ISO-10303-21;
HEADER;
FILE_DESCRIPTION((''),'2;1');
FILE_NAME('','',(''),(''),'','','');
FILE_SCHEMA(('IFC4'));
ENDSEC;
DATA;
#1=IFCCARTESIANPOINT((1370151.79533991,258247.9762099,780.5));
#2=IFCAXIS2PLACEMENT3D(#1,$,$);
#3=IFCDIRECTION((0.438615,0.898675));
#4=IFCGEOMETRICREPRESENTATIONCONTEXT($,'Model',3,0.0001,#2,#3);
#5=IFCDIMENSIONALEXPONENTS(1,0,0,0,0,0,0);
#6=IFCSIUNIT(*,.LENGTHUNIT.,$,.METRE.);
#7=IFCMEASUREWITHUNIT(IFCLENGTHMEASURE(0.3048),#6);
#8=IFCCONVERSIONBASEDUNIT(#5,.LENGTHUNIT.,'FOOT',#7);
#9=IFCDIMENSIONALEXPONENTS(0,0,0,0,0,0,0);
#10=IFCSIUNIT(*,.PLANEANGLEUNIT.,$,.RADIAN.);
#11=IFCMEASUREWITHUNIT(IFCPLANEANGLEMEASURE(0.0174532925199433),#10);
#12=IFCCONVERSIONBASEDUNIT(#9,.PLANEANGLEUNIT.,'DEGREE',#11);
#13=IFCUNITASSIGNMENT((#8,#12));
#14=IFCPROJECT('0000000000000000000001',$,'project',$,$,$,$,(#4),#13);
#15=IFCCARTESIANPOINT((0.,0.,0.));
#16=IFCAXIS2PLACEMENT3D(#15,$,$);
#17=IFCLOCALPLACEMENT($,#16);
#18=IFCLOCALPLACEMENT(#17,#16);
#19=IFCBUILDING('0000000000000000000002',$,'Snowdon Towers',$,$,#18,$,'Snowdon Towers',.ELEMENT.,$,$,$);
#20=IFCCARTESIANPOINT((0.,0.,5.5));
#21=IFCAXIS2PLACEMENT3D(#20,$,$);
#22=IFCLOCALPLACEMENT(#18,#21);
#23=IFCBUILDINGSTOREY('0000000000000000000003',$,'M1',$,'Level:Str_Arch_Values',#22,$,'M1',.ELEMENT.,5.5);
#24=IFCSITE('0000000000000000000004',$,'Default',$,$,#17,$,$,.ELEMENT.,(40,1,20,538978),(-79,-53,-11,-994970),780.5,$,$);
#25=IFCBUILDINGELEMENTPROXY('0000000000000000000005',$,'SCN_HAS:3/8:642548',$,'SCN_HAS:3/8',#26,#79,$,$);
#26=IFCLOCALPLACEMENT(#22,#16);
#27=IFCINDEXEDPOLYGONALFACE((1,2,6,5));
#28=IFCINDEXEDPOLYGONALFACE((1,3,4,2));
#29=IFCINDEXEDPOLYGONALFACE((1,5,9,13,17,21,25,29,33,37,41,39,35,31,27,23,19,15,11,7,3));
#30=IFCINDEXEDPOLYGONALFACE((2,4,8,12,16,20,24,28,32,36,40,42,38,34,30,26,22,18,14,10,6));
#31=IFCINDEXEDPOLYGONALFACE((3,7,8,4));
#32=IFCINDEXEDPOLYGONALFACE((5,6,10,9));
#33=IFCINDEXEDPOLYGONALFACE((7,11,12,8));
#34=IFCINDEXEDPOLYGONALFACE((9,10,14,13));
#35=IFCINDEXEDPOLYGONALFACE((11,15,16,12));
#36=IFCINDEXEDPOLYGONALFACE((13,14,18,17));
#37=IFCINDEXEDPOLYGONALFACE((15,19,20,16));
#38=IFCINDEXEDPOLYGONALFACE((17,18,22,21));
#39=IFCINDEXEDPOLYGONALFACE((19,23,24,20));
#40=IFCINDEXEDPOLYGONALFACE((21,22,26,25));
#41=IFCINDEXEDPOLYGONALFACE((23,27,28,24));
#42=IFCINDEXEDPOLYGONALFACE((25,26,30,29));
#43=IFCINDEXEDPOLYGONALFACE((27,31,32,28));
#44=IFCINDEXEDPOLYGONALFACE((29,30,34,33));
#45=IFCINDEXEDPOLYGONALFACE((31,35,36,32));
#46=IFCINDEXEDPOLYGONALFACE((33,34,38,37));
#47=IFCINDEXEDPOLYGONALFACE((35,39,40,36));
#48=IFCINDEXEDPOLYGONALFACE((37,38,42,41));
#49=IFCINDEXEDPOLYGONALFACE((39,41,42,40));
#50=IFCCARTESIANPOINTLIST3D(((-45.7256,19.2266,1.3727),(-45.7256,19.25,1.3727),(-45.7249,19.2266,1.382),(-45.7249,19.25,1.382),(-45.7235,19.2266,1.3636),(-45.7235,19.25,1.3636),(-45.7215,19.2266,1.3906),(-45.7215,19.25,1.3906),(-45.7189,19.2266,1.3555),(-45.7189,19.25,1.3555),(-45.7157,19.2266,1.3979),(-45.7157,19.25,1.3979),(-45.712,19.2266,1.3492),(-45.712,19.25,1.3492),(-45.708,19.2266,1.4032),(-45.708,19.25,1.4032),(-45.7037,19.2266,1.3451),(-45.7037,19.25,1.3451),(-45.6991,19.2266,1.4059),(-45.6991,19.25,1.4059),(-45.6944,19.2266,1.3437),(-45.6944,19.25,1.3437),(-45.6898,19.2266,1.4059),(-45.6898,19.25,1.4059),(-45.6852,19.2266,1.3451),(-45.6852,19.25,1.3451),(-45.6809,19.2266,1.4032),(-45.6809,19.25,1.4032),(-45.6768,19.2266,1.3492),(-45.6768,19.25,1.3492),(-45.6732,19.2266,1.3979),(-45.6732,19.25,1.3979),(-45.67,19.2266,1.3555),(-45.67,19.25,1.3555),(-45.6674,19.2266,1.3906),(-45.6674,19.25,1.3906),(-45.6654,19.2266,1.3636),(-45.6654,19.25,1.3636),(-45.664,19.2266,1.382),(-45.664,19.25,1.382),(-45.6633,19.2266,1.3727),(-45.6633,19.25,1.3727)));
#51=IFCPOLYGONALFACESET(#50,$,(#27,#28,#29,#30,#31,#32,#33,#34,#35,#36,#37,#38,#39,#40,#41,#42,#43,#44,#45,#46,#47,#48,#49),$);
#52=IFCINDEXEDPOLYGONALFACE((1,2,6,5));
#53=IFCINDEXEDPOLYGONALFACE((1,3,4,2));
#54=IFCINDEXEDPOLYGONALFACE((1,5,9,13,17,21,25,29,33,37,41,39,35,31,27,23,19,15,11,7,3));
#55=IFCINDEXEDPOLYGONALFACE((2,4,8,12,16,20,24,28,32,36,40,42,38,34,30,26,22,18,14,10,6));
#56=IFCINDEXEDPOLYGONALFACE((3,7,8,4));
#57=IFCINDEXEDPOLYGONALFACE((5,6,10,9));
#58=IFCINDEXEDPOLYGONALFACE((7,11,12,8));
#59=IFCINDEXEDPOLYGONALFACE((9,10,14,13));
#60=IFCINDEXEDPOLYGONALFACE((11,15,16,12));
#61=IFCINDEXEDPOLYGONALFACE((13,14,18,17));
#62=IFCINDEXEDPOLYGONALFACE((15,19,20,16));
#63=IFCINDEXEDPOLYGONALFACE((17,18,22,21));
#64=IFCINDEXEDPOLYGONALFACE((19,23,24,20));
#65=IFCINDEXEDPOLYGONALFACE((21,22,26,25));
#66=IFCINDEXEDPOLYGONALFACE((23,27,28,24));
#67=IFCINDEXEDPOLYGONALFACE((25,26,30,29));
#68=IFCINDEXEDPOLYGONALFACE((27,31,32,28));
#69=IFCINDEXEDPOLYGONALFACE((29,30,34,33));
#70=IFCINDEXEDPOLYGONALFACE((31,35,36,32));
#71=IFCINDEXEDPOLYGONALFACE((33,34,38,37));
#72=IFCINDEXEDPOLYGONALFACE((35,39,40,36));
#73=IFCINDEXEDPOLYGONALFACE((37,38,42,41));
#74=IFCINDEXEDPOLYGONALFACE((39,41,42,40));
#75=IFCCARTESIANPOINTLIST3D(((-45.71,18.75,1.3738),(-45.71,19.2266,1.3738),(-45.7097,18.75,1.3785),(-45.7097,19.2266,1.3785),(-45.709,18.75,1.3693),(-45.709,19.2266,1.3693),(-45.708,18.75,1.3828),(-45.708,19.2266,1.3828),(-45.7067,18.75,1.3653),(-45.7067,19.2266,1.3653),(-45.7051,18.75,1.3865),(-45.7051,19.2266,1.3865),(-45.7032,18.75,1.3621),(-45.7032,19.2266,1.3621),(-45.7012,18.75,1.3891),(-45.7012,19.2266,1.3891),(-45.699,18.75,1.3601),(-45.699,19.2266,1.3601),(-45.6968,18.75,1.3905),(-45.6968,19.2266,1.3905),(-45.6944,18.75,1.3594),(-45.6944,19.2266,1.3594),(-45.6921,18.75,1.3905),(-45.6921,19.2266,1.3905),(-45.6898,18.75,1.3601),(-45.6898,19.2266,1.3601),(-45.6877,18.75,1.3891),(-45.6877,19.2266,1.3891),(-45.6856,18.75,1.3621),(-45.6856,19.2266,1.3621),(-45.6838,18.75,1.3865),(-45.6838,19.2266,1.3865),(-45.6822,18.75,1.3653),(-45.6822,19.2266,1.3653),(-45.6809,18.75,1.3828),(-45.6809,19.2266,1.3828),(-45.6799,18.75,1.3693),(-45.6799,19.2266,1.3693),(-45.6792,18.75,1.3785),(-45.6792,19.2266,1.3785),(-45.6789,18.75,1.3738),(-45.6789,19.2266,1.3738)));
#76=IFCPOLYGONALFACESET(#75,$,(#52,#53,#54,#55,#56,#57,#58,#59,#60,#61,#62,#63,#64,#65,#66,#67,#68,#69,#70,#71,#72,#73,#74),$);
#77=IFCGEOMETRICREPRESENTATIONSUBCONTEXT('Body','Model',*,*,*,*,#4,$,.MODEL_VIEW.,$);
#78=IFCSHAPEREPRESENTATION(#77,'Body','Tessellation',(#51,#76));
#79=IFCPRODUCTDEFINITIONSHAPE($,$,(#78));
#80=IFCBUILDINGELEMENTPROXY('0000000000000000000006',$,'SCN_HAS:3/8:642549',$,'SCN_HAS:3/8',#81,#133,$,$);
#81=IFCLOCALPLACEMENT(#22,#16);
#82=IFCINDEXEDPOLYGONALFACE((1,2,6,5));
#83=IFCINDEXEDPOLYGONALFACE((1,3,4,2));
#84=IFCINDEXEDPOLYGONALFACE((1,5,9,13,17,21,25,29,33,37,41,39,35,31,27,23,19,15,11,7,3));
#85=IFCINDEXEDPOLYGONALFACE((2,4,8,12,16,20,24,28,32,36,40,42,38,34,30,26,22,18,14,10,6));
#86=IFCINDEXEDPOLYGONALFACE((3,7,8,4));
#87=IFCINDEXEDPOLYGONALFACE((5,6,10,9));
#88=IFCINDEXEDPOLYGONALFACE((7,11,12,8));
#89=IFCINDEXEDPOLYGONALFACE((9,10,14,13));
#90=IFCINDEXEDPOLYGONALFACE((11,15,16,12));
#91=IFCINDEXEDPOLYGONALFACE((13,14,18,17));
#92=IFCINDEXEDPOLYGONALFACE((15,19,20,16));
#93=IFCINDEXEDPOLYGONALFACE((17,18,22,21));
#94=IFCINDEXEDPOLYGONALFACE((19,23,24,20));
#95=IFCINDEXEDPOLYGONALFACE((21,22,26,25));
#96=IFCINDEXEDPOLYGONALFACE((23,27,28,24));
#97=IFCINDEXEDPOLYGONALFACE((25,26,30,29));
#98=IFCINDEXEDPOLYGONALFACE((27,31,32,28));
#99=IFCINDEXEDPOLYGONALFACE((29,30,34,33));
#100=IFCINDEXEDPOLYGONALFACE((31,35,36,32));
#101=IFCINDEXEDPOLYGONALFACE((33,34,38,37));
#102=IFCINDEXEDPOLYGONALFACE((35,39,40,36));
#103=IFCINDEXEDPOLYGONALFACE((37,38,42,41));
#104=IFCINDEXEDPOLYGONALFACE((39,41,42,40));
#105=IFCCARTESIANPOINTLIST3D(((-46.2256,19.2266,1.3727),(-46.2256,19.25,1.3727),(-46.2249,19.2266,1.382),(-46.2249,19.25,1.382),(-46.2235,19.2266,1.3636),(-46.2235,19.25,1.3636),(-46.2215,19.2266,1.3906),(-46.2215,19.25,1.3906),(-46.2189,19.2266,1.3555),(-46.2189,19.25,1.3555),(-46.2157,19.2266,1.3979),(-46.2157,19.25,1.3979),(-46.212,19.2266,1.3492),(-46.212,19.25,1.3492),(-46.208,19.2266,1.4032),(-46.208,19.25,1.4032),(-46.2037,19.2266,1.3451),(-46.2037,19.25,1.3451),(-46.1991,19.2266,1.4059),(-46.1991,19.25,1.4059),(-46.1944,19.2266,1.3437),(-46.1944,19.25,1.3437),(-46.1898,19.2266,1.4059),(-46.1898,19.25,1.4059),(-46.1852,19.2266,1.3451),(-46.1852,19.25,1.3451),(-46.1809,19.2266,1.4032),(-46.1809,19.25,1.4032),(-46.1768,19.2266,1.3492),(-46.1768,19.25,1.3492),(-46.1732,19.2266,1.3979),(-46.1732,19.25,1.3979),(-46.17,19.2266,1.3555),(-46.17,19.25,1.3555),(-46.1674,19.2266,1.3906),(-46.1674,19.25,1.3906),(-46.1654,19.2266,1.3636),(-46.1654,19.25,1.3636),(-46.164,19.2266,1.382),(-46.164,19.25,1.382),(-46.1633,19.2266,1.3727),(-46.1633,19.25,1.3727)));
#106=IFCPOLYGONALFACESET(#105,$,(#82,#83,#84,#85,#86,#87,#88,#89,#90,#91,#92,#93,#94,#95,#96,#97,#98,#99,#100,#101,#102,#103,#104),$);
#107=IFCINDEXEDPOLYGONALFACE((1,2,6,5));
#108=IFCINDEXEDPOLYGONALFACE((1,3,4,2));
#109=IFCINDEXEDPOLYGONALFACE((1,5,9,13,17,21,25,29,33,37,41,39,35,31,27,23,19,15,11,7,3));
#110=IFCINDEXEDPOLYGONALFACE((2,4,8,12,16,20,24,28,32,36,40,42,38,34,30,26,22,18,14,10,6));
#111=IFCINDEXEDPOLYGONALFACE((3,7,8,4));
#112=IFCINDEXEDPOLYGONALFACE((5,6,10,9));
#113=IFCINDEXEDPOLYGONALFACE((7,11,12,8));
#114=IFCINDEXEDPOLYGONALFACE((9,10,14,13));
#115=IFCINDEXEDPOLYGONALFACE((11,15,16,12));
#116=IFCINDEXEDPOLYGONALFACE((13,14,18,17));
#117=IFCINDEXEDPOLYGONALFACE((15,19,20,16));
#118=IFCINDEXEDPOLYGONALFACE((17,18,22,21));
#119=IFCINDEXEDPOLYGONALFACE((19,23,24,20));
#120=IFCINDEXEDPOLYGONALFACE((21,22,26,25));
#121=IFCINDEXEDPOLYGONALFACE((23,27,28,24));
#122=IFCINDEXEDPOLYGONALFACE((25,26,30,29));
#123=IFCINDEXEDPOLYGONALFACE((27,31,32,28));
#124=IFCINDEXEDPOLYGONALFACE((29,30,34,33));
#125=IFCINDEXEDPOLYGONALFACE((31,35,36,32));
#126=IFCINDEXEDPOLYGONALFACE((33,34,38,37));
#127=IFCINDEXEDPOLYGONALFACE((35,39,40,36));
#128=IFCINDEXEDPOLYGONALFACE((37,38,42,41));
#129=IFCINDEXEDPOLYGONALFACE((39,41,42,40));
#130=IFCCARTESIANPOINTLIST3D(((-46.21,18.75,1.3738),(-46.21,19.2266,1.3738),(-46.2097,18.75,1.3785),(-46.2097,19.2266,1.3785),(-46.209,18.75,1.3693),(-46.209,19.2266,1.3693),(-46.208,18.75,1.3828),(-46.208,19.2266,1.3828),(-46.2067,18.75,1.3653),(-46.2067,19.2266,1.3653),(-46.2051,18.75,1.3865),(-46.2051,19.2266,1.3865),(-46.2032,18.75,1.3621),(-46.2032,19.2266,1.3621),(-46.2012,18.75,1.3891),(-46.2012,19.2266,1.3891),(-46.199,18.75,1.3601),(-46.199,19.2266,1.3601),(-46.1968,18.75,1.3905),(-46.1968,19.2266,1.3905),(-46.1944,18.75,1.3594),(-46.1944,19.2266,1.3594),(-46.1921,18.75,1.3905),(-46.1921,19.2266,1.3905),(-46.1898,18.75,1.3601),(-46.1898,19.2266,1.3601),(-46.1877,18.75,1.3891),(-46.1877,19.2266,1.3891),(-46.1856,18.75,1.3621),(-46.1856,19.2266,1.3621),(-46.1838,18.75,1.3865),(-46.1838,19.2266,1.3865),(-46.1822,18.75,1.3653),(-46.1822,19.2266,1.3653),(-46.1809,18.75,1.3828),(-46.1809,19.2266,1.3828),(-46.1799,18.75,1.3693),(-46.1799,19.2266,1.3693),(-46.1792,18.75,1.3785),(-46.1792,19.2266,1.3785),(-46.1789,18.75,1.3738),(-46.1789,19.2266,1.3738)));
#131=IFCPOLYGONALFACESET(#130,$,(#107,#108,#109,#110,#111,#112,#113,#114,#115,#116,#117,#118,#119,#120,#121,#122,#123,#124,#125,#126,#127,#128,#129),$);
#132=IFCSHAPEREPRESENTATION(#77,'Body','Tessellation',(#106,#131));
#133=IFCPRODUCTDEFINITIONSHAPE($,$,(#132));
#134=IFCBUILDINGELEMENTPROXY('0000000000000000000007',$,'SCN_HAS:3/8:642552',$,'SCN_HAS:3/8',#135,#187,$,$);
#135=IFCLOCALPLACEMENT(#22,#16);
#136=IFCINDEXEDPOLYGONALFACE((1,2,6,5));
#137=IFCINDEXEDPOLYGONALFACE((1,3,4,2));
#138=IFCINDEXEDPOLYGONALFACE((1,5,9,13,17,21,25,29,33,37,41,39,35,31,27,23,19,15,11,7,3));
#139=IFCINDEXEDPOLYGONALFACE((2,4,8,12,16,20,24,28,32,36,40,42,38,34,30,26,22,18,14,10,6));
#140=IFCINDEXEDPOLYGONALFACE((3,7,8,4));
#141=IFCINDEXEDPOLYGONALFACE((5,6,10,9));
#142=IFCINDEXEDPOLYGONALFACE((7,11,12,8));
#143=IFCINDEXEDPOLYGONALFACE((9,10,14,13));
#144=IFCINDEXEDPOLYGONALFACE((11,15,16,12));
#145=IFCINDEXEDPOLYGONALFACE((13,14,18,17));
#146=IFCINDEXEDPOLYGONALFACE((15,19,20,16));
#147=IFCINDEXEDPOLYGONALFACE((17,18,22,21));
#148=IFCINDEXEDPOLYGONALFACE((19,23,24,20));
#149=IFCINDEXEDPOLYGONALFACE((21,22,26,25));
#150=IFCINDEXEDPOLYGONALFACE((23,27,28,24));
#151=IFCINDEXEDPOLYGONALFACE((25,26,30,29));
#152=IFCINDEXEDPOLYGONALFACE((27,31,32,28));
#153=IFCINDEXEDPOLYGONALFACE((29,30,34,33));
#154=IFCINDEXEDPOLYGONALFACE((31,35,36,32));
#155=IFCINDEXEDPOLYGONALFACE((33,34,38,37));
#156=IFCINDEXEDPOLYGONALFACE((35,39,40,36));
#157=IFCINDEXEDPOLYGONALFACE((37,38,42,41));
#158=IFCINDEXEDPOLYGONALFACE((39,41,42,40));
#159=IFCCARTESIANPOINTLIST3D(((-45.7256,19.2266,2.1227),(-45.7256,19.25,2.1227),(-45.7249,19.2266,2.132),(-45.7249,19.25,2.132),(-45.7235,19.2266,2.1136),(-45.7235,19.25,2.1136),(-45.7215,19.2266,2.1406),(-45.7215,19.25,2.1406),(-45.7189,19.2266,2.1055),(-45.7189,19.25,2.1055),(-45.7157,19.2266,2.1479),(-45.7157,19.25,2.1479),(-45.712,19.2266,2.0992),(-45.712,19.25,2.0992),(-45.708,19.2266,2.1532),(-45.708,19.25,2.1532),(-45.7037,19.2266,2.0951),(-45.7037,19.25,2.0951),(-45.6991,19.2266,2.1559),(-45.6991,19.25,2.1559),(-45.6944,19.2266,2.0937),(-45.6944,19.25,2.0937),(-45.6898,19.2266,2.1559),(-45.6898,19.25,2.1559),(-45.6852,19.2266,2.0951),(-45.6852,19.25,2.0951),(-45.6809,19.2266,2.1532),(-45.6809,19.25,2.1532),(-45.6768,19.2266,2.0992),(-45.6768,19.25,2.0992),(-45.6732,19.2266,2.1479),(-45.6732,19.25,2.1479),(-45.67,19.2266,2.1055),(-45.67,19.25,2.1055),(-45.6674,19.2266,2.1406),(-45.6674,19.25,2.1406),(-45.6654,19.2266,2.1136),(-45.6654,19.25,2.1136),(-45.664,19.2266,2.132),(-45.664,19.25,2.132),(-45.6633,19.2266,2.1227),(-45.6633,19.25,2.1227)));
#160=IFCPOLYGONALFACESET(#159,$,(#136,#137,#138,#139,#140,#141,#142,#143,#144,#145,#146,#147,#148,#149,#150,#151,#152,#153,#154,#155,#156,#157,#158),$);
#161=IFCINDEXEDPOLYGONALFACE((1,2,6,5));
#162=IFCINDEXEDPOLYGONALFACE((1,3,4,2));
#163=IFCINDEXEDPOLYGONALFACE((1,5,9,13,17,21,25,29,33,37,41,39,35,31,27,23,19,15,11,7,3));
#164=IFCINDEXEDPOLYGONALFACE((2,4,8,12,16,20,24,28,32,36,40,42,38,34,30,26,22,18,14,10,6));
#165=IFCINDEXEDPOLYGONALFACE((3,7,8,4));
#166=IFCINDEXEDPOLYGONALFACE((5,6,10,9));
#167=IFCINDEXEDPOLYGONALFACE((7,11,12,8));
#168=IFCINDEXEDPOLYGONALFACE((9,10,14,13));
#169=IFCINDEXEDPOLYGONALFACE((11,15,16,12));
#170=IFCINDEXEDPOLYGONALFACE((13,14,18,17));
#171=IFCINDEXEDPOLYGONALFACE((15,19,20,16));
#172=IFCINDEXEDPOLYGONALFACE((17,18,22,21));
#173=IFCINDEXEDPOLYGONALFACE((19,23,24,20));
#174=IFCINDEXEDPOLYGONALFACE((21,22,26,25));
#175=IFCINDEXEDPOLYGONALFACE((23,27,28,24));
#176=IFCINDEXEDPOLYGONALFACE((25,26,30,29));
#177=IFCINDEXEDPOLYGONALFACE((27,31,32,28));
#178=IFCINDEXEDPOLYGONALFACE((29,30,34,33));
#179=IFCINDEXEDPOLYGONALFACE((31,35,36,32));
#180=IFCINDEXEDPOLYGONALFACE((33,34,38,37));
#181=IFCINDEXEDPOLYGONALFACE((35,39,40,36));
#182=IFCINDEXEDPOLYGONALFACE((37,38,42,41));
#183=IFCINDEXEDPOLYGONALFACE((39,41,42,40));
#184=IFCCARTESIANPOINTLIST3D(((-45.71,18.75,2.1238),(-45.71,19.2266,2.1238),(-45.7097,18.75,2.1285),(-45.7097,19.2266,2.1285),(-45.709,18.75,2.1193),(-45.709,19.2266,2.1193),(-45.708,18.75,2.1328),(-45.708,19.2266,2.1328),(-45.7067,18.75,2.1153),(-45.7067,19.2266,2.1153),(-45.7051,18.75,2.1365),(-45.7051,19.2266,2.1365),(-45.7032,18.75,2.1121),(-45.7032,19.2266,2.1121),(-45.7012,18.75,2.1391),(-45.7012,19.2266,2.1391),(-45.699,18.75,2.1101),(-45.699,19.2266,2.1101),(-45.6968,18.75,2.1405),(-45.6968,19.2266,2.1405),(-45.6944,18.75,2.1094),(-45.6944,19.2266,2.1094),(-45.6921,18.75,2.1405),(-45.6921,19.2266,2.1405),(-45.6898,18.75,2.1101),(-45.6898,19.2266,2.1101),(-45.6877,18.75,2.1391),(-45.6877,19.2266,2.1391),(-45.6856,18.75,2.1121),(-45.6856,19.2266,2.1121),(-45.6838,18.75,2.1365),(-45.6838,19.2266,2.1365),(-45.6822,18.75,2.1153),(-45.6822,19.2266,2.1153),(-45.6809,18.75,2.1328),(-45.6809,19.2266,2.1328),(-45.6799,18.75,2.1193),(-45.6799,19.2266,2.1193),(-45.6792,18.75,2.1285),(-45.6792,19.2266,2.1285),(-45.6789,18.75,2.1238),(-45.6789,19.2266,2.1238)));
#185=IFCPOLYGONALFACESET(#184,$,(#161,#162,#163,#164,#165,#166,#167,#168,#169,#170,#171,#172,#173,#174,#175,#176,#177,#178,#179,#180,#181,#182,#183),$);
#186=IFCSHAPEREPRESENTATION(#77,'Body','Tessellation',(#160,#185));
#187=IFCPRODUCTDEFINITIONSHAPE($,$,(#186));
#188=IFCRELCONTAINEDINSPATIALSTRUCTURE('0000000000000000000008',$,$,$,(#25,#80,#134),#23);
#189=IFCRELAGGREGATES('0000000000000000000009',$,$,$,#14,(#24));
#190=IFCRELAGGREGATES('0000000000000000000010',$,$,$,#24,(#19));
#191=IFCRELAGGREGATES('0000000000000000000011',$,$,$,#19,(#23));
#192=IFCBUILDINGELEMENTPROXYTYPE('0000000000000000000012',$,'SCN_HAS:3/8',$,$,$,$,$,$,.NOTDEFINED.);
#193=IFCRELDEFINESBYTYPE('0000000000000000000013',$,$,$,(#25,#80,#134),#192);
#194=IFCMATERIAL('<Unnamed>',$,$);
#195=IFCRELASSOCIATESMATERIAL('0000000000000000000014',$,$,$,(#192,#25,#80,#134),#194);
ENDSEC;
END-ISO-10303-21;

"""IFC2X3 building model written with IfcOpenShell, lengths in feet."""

from ifc_helpers import new_model, entity, si_unit, converted_unit, direction, frame, frame_2d, origin, place, context, subcontext, project, spatial, circle, extrude, source, transform, mapped, material, type_object, type_shapes, element, save


model = new_model("IFC2X3")

# Units and contexts
model_context = context("Model", 3, precision=0.0001, world=frame((1370151.79533991, 258247.9762099, 780.5)), true_north=direction((0.438615, 0.898675)))
body_context = subcontext(model_context, "Body", "Model", "MODEL_VIEW")
ifc_project = project(units=[converted_unit("LENGTHUNIT", "FOOT", entity("IfcLengthMeasure", 0.3048), si_unit("LENGTHUNIT", "METRE"), dimensions=[1, 0, 0, 0, 0, 0, 0]), converted_unit("PLANEANGLEUNIT", "DEGREE", entity("IfcPlaneAngleMeasure", 0.0174532925199433), si_unit("PLANEANGLEUNIT", "RADIAN"), dimensions=[0, 0, 0, 0, 0, 0, 0])], contexts=[model_context])

# Site, building, storey
site_placement = place(None, origin())
site = spatial("IfcSite", under=ifc_project, at=site_placement, Name="Default", CompositionType="ELEMENT", RefLatitude=(40, 1, 20, 538978), RefLongitude=(-79, -53, -11, -994970), RefElevation=780.5)
building_placement = place(site_placement, origin())
building = spatial("IfcBuilding", under=site, at=building_placement, Name="Snowdon Towers", LongName="Snowdon Towers", CompositionType="ELEMENT")
storey_placement = place(building_placement, frame((0.0, 0.0, 5.5)))
storey = spatial("IfcBuildingStorey", under=building, at=storey_placement, Name="M1", ObjectType="Level:Str_Arch_Values", LongName="M1", CompositionType="ELEMENT", Elevation=5.5)

# Building element proxies
ifc_material_1 = material(Name="<Unnamed>")
building_element_proxy_type = type_object("IfcBuildingElementProxyType", Name="SCN_HAS:3/8", PredefinedType="NOTDEFINED", material=ifc_material_1)
shared_shape = source(origin(), body_context, "Body", "SweptSolid", [
    extrude(circle(Radius=0.0312, at=frame_2d((0.0, 0.0), x_axis=(1.0, 0.0))), frame((0.0, 0.0, -0.5), z_axis=(0.0, 0.0, 1.0), x_axis=(0.0, -1.0, 0.0)), (0.0, 0.0, 1.0), 0.0234),
    extrude(circle(Radius=0.0156, at=frame_2d((0.0, 0.0), x_axis=(1.0, 0.0))), frame((0.0, 0.0, -0.4766), z_axis=(0.0, 0.0, 1.0), x_axis=(0.0, -1.0, 0.0)), (0.0, 0.0, 1.0), 0.4766),
])
type_shapes(building_element_proxy_type, [shared_shape])
for number, where, z_axis, x_axis, name in (
    (1, (-45.6944, 18.75, 1.375), (0.0, -1.0, 0.0), (1.0, 0.0, 0.0), "SCN_HAS:3/8:642548"),
    (2, (-46.1944, 18.75, 1.375), (0.0, -1.0, 0.0), (1.0, 0.0, 0.0), "SCN_HAS:3/8:642549"),
    (3, (-45.6944, 18.75, 2.125), (0.0, -1.0, 0.0), (1.0, 0.0, 0.0), "SCN_HAS:3/8:642552"),
):
    element("IfcBuildingElementProxy", number, at=place(storey_placement, frame(where, z_axis=z_axis, x_axis=x_axis)), inside=storey, type_object=building_element_proxy_type, material=ifc_material_1, Name=name, ObjectType="SCN_HAS:3/8", context=body_context, shape_type="MappedRepresentation", body=[
        mapped(shared_shape, transform((0.0, 0.0, 0.0), scale=1.0)),
    ])

save(model, "model.ifc")
